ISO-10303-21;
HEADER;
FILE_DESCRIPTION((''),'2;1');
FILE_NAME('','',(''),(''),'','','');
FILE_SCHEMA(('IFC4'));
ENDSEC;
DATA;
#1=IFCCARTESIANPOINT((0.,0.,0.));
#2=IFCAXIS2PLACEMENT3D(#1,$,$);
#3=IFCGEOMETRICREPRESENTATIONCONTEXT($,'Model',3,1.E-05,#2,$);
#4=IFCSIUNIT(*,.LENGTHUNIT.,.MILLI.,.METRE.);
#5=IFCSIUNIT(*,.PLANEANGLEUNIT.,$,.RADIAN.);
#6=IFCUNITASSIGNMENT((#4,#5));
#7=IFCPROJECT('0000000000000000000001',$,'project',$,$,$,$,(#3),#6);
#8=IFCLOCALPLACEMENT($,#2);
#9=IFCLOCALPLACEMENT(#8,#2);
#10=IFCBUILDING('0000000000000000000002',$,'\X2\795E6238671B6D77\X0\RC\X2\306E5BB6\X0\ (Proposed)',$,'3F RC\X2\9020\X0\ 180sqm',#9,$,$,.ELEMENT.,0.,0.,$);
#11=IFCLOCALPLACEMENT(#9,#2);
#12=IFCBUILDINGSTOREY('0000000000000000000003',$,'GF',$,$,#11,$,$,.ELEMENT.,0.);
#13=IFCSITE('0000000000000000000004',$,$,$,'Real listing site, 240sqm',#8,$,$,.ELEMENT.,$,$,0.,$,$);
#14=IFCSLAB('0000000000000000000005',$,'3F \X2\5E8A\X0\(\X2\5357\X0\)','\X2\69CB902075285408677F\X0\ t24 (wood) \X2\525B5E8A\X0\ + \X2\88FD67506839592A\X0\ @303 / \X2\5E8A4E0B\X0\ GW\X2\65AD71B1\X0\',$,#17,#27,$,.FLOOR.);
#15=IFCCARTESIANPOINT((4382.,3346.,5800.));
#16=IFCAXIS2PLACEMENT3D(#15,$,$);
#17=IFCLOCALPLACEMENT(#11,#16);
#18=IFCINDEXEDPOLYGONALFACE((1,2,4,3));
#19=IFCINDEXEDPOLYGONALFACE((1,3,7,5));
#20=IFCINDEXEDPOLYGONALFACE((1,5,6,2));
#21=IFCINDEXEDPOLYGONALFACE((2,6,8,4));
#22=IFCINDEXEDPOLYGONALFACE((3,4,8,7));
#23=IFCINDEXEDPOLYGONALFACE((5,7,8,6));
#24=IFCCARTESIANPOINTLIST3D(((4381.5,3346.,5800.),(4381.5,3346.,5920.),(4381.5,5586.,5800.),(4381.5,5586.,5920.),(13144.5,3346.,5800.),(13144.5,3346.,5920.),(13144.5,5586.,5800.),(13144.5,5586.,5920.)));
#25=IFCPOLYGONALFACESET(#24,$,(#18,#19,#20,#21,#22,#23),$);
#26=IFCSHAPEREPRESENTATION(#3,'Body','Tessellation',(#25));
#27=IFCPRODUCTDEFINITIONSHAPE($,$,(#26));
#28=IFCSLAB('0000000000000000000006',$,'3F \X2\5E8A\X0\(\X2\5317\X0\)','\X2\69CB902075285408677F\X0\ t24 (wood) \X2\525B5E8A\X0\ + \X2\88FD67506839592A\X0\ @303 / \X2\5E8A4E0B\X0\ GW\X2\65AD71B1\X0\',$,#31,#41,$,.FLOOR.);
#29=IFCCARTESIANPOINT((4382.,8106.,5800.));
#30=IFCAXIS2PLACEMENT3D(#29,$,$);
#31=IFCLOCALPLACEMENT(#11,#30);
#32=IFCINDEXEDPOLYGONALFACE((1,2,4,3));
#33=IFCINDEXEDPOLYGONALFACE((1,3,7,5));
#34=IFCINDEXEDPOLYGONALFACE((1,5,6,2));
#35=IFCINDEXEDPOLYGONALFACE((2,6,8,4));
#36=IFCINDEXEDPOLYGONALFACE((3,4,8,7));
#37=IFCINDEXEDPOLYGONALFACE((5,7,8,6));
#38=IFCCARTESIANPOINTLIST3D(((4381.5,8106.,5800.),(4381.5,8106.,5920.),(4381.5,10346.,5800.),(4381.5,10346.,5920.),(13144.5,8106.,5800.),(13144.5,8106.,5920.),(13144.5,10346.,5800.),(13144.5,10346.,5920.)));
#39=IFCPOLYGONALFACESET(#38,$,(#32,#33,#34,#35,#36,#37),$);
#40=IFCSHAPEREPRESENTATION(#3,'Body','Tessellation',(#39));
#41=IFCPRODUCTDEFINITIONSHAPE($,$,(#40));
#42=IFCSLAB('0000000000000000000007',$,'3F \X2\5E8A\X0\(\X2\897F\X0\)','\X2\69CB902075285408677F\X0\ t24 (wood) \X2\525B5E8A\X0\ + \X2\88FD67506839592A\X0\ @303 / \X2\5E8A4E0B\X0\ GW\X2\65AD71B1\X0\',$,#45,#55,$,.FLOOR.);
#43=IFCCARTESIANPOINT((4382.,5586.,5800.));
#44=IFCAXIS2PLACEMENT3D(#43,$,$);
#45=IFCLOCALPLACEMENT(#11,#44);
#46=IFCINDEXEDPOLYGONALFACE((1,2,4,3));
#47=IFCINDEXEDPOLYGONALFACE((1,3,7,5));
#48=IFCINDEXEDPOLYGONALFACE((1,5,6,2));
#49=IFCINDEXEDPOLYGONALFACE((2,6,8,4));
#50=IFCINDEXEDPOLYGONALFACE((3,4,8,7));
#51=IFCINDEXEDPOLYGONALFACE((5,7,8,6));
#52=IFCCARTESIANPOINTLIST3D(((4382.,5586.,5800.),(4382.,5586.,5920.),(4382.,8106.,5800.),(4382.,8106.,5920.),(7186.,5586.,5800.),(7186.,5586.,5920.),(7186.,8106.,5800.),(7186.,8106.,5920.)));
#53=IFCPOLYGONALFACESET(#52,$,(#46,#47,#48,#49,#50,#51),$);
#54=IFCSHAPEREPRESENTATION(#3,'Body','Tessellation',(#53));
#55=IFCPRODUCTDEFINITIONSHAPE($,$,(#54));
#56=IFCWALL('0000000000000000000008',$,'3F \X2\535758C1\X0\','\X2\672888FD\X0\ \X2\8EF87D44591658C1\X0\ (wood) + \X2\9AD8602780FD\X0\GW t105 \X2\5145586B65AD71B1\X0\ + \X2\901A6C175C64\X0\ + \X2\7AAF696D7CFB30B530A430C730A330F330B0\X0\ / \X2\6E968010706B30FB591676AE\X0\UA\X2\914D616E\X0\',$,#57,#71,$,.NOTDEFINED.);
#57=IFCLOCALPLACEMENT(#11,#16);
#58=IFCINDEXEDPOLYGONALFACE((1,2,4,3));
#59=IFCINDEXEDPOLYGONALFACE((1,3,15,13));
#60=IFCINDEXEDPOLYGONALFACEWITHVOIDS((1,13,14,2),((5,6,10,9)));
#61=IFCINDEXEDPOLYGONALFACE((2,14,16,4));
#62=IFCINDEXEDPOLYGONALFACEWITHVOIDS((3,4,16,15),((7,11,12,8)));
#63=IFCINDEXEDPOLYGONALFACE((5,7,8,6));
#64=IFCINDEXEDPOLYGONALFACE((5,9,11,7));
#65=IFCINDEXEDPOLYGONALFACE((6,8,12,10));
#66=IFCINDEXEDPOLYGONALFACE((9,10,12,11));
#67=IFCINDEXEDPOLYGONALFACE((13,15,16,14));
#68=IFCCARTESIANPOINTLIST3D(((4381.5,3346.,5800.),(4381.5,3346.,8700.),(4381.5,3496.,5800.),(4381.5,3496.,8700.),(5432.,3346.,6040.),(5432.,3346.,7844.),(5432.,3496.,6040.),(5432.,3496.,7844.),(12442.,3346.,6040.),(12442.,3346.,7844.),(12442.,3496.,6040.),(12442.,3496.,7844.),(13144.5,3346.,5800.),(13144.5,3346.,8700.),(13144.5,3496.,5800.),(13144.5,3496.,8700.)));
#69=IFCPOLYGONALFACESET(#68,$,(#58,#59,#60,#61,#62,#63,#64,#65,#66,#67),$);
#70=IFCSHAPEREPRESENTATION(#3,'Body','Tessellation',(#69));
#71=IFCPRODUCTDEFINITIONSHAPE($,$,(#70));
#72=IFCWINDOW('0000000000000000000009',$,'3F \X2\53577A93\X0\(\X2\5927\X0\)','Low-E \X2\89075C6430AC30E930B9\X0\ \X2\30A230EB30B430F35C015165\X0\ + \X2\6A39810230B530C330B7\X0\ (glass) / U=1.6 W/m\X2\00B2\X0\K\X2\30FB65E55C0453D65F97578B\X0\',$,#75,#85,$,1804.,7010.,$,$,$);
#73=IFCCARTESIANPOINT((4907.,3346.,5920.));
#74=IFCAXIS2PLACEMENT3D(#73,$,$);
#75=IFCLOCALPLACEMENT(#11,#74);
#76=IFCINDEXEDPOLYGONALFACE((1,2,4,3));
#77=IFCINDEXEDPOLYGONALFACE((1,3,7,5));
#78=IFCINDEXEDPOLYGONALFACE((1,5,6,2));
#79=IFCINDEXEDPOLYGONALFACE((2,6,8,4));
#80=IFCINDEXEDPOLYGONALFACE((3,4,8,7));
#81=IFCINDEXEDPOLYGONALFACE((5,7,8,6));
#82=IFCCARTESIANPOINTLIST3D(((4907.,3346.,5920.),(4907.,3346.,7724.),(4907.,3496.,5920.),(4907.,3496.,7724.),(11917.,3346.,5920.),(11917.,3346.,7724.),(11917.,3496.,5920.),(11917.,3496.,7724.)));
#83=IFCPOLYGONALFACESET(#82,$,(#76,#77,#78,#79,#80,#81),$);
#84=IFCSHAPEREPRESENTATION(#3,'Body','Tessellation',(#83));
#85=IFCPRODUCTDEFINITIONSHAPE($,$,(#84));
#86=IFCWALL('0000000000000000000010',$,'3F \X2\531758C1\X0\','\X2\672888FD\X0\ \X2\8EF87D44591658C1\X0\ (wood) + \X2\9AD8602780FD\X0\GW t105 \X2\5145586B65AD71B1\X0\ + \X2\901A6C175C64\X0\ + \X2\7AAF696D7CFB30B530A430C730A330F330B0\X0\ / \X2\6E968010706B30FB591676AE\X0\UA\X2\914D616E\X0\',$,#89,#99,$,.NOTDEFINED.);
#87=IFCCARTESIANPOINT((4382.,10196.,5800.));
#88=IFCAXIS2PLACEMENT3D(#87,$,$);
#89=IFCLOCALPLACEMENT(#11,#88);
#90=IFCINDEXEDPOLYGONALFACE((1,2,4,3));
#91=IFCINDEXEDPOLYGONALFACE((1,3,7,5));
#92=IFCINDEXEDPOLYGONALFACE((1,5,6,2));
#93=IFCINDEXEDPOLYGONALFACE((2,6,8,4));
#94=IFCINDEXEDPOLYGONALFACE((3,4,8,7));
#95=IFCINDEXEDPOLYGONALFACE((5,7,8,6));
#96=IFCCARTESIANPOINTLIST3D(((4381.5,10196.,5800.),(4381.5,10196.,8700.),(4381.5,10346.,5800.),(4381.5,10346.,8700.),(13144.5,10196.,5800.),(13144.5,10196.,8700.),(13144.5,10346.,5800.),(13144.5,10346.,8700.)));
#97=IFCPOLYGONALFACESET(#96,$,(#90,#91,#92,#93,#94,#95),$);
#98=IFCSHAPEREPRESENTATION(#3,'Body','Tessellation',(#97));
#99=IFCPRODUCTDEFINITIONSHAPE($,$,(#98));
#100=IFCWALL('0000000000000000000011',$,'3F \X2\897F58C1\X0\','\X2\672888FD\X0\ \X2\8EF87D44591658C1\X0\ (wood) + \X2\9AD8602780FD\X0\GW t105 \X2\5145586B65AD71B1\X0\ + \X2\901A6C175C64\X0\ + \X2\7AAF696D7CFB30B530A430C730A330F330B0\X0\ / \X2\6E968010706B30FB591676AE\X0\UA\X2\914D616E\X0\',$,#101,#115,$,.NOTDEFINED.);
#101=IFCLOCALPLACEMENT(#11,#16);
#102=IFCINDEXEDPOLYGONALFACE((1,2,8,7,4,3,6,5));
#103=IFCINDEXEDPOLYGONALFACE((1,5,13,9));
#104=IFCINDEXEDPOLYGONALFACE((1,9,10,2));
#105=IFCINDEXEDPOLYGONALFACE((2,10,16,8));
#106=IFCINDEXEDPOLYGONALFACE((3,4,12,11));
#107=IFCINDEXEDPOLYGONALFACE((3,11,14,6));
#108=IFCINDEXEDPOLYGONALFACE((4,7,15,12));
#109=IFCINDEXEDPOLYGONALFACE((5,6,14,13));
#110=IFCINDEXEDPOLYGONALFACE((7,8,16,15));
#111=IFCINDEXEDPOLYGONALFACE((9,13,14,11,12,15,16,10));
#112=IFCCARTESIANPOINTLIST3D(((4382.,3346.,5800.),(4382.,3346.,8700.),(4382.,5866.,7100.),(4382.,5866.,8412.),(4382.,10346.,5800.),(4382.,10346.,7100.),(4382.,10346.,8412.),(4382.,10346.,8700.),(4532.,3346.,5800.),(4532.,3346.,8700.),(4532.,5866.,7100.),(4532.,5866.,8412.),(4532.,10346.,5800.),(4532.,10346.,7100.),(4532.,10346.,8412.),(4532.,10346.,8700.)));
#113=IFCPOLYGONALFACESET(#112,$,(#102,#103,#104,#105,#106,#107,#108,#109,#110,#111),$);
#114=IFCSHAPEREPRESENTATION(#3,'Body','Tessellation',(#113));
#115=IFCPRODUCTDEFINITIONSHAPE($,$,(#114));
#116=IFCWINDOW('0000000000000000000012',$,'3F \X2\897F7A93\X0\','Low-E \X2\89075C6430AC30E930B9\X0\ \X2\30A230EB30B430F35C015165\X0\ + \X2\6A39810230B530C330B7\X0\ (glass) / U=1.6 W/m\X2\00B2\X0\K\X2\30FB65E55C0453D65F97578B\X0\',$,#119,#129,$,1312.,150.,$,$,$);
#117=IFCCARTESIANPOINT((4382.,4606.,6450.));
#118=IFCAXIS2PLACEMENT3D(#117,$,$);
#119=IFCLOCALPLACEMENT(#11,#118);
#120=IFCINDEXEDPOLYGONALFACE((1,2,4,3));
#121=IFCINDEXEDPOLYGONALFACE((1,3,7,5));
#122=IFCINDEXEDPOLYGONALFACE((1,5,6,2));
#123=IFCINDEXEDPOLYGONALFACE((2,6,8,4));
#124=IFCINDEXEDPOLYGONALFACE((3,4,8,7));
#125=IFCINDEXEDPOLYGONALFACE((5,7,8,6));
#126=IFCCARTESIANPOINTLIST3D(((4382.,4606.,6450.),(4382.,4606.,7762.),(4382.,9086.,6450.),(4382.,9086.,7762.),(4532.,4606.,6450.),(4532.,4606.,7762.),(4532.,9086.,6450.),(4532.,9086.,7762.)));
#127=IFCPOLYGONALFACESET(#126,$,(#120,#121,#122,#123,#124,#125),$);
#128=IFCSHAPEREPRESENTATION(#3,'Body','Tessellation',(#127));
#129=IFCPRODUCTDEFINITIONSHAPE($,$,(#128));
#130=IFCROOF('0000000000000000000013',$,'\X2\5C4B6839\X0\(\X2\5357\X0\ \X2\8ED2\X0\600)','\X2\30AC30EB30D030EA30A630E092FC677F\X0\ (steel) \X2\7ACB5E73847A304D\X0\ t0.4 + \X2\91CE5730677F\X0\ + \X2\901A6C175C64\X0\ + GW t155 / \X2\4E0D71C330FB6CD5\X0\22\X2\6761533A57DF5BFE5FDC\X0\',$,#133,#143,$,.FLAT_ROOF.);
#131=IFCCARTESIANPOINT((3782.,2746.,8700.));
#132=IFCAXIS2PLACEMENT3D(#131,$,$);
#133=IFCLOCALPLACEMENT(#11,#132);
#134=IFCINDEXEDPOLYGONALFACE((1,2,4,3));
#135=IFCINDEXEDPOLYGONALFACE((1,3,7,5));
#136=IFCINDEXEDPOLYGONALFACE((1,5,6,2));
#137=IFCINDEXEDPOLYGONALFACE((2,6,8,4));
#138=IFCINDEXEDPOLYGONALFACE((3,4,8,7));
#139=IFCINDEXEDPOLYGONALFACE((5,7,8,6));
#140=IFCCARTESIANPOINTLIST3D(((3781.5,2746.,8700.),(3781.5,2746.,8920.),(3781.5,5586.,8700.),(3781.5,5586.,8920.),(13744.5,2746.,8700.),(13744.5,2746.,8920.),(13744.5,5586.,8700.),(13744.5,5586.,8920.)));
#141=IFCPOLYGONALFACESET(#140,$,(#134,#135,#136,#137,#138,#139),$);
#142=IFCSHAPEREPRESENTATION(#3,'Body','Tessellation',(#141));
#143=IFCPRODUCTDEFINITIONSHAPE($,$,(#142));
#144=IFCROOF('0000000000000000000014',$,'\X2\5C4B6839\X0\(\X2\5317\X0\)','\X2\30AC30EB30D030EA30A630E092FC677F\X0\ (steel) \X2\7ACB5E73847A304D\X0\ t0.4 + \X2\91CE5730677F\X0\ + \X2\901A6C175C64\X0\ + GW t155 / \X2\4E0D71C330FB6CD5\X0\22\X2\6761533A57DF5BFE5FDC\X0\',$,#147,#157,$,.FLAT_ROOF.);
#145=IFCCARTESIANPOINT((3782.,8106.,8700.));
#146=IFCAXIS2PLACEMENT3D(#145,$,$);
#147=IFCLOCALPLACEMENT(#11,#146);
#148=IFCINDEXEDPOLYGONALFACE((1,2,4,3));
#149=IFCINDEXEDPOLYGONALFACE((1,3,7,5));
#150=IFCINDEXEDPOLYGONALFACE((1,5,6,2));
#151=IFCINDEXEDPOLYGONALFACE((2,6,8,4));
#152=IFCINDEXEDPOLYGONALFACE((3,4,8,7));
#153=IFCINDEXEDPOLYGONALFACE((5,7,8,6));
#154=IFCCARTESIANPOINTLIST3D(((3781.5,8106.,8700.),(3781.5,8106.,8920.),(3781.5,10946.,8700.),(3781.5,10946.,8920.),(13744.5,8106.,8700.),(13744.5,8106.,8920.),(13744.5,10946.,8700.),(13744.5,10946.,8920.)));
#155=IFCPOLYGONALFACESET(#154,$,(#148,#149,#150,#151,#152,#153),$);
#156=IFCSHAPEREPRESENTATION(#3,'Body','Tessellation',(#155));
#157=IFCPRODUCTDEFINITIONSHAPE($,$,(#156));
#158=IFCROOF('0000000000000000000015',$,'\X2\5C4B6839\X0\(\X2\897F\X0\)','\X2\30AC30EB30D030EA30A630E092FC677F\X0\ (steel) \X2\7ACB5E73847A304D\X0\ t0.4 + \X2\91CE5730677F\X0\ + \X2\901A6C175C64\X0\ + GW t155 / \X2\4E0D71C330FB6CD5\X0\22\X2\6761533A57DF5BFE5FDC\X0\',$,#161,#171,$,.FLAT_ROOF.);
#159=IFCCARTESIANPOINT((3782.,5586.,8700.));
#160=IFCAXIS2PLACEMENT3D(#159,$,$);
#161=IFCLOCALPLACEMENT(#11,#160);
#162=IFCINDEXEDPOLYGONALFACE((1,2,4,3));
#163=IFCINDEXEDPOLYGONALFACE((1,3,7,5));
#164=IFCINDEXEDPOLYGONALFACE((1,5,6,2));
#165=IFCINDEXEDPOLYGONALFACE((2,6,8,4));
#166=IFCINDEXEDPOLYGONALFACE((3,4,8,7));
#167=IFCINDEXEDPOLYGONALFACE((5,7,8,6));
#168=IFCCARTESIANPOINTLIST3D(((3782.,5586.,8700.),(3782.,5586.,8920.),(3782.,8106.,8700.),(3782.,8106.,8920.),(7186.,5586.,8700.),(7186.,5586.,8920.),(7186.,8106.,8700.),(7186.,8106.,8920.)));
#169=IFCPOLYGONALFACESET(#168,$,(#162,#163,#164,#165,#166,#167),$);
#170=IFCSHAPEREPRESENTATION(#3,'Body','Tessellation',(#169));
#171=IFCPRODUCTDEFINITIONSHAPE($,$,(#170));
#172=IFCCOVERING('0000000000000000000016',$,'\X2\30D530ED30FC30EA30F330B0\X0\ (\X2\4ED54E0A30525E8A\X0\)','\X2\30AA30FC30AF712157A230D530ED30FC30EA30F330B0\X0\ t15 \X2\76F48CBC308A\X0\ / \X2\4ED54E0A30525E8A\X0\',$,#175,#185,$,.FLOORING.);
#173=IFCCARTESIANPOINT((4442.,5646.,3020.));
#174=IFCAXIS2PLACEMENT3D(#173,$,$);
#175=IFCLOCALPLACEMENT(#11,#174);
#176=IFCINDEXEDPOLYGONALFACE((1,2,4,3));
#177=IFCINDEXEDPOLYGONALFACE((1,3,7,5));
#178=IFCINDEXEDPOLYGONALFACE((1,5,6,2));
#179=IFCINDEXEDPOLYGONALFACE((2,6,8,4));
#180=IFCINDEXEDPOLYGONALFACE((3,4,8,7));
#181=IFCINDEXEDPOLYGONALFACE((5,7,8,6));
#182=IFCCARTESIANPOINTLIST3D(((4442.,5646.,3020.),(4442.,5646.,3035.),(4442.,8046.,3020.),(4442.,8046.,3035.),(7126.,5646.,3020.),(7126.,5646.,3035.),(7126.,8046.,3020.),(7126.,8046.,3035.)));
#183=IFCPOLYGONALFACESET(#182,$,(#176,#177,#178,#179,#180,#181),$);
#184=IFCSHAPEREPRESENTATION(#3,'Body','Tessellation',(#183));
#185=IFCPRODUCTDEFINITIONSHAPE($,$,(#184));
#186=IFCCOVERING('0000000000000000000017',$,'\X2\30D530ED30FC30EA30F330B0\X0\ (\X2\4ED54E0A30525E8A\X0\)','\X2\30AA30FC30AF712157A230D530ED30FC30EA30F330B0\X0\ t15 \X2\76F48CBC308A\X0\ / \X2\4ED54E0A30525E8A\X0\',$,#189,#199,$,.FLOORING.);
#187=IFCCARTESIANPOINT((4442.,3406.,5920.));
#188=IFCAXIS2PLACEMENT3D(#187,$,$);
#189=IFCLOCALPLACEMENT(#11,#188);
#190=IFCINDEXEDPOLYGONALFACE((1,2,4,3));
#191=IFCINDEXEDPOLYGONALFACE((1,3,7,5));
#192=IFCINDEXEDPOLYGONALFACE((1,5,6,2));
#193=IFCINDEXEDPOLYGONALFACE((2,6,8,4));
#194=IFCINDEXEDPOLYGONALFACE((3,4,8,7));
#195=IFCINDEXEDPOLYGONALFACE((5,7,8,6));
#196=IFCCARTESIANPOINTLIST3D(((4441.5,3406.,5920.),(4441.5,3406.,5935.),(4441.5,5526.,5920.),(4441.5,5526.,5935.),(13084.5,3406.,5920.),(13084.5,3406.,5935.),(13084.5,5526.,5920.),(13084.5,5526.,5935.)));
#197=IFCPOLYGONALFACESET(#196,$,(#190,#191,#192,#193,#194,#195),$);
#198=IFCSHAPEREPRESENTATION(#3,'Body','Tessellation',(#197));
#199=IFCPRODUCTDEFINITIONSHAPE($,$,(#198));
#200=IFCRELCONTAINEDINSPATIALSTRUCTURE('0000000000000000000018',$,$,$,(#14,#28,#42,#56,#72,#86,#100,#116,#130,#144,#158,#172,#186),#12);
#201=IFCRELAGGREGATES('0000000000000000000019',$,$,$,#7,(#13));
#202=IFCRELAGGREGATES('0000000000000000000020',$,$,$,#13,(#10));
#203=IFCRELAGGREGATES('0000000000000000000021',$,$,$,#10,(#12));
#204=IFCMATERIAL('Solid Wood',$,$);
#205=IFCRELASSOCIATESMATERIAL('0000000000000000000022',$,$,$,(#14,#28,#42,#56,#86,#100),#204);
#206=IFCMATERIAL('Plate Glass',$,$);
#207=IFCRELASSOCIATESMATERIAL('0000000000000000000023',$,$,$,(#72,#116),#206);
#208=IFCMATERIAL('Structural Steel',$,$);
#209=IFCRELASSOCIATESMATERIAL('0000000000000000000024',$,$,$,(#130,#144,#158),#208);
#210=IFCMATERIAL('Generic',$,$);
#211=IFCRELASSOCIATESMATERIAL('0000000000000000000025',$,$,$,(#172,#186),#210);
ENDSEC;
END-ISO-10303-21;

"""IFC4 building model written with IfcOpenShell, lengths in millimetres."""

from ifc_helpers import new_model, si_unit, frame, frame_2d, origin, place, context, project, spatial, rectangle, extrude, material, element, fill, save


model = new_model("IFC4")

# Units and contexts
model_context = context("Model", 3, precision=1e-05, world=origin())
ifc_project = project(units=[si_unit("LENGTHUNIT", "METRE", prefix="MILLI"), si_unit("PLANEANGLEUNIT", "RADIAN")], contexts=[model_context])

# Site, building, storey
site_placement = place(None, origin())
site = spatial("IfcSite", under=ifc_project, at=site_placement, ObjectType="Real listing site, 240sqm", CompositionType="ELEMENT", RefElevation=0.0)
building_placement = place(site_placement, origin())
building = spatial("IfcBuilding", under=site, at=building_placement, Name="神戸望海RCの家 (Proposed)", ObjectType="3F RC造 180sqm", CompositionType="ELEMENT", ElevationOfRefHeight=0.0, ElevationOfTerrain=0.0)
storey_placement = place(building_placement, origin())
storey = spatial("IfcBuildingStorey", under=building, at=storey_placement, Name="GF", CompositionType="ELEMENT", Elevation=0.0)

# Slabs
ifc_material_1 = material(Name="Solid Wood")
slab_1_placement = place(storey_placement, frame((4382.0, 3346.0, 5800.0)))
element("IfcSlab", 1, at=slab_1_placement, inside=storey, material=ifc_material_1, Name="3F 床(南)", Description="構造用合板 t24 (wood) 剛床 + 製材根太 @303 / 床下 GW断熱", PredefinedType="FLOOR", context=model_context, shape_type="SweptSolid", body=[
    extrude(rectangle(XDim=8763.0, YDim=2240.0, at=frame_2d((4381.0, 1120.0))), frame((4382.0, 3346.0, 5800.0)), (0.0, 0.0, 1.0), 120.0),
])
slab_2_placement = place(storey_placement, frame((4382.0, 8106.0, 5800.0)))
element("IfcSlab", 2, at=slab_2_placement, inside=storey, material=ifc_material_1, Name="3F 床(北)", Description="構造用合板 t24 (wood) 剛床 + 製材根太 @303 / 床下 GW断熱", PredefinedType="FLOOR", context=model_context, shape_type="SweptSolid", body=[
    extrude(rectangle(XDim=8763.0, YDim=2240.0, at=frame_2d((4381.0, 1120.0))), frame((4382.0, 8106.0, 5800.0)), (0.0, 0.0, 1.0), 120.0),
])
slab_3_placement = place(storey_placement, frame((4382.0, 5586.0, 5800.0)))
element("IfcSlab", 3, at=slab_3_placement, inside=storey, material=ifc_material_1, Name="3F 床(西)", Description="構造用合板 t24 (wood) 剛床 + 製材根太 @303 / 床下 GW断熱", PredefinedType="FLOOR", context=model_context, shape_type="SweptSolid", body=[
    extrude(rectangle(XDim=2804.0, YDim=2520.0, at=frame_2d((1402.0, 1260.0))), frame((4382.0, 5586.0, 5800.0)), (0.0, 0.0, 1.0), 120.0),
])

# Wall, opening, window
wall_1_placement = place(storey_placement, frame((4382.0, 3346.0, 5800.0)))
wall_1 = element("IfcWall", 4, at=wall_1_placement, inside=storey, material=ifc_material_1, Name="3F 南壁", Description="木製 軸組外壁 (wood) + 高性能GW t105 充填断熱 + 通気層 + 窯業系サイディング / 準耐火・外皮UA配慮", PredefinedType="NOTDEFINED", context=model_context, shape_type="SweptSolid", body=[
    extrude(rectangle(XDim=8763.0, YDim=150.0, at=frame_2d((4381.0, 75.0))), frame((4382.0, 3346.0, 5800.0)), (0.0, 0.0, 1.0), 2900.0),
])
opening_1_placement = place(storey_placement, frame((4907.0, 3346.0, 5920.0)))
opening_1 = element("IfcOpeningElement", 5, at=opening_1_placement, cuts=wall_1, PredefinedType="NOTDEFINED", context=model_context, shape_type="SweptSolid", body=[
    extrude(rectangle(XDim=7010.0, YDim=150.0, at=frame_2d((3505.0, 75.0))), frame((4907.0, 3346.0, 5920.0)), (0.0, 0.0, 1.0), 1804.0),
])
ifc_material_2 = material(Name="Plate Glass")
window_1_placement = place(storey_placement, frame((4907.0, 3346.0, 5920.0)))
window_1 = element("IfcWindow", 6, at=window_1_placement, inside=storey, material=ifc_material_2, Name="3F 南窓(大)", Description="Low-E 複層ガラス アルゴン封入 + 樹脂サッシ (glass) / U=1.6 W/m²K・日射取得型", OverallHeight=1804.0, OverallWidth=7010.0, context=model_context, shape_type="SweptSolid", body=[
    extrude(rectangle(XDim=7010.0, YDim=150.0, at=frame_2d((3505.0, 75.0))), frame((4907.0, 3346.0, 5920.0)), (0.0, 0.0, 1.0), 1804.0),
])
fill(opening_1, window_1)

# Wall
wall_2_placement = place(storey_placement, frame((4382.0, 10196.0, 5800.0)))
element("IfcWall", 7, at=wall_2_placement, inside=storey, material=ifc_material_1, Name="3F 北壁", Description="木製 軸組外壁 (wood) + 高性能GW t105 充填断熱 + 通気層 + 窯業系サイディング / 準耐火・外皮UA配慮", PredefinedType="NOTDEFINED", context=model_context, shape_type="SweptSolid", body=[
    extrude(rectangle(XDim=8763.0, YDim=150.0, at=frame_2d((4381.0, 75.0))), frame((4382.0, 10196.0, 5800.0)), (0.0, 0.0, 1.0), 2900.0),
])

# Wall, opening, window
wall_3_placement = place(storey_placement, frame((4382.0, 3346.0, 5800.0)))
wall_3 = element("IfcWall", 8, at=wall_3_placement, inside=storey, material=ifc_material_1, Name="3F 西壁", Description="木製 軸組外壁 (wood) + 高性能GW t105 充填断熱 + 通気層 + 窯業系サイディング / 準耐火・外皮UA配慮", PredefinedType="NOTDEFINED", context=model_context, shape_type="SweptSolid", body=[
    extrude(rectangle(XDim=150.0, YDim=7000.0, at=frame_2d((75.0, 3500.0))), frame((4382.0, 3346.0, 5800.0)), (0.0, 0.0, 1.0), 2900.0),
])
opening_2_placement = place(storey_placement, frame((4382.0, 4606.0, 6450.0)))
opening_2 = element("IfcOpeningElement", 9, at=opening_2_placement, cuts=wall_3, PredefinedType="NOTDEFINED", context=model_context, shape_type="SweptSolid", body=[
    extrude(rectangle(XDim=150.0, YDim=4480.0, at=frame_2d((75.0, 2240.0))), frame((4382.0, 4606.0, 6450.0)), (0.0, 0.0, 1.0), 1312.0),
])
window_2_placement = place(storey_placement, frame((4382.0, 4606.0, 6450.0)))
window_2 = element("IfcWindow", 10, at=window_2_placement, inside=storey, material=ifc_material_2, Name="3F 西窓", Description="Low-E 複層ガラス アルゴン封入 + 樹脂サッシ (glass) / U=1.6 W/m²K・日射取得型", OverallHeight=1312.0, OverallWidth=150.0, context=model_context, shape_type="SweptSolid", body=[
    extrude(rectangle(XDim=150.0, YDim=4480.0, at=frame_2d((75.0, 2240.0))), frame((4382.0, 4606.0, 6450.0)), (0.0, 0.0, 1.0), 1312.0),
])
fill(opening_2, window_2)

# Roofs
ifc_material_3 = material(Name="Structural Steel")
roof_1_placement = place(storey_placement, frame((3782.0, 2746.0, 8700.0)))
element("IfcRoof", 11, at=roof_1_placement, inside=storey, material=ifc_material_3, Name="屋根(南 軒600)", Description="ガルバリウム鋼板 (steel) 立平葺き t0.4 + 野地板 + 通気層 + GW t155 / 不燃・法22条区域対応", PredefinedType="FLAT_ROOF", context=model_context, shape_type="SweptSolid", body=[
    extrude(rectangle(XDim=9963.0, YDim=2840.0, at=frame_2d((4981.0, 1420.0))), frame((3782.0, 2746.0, 8700.0)), (0.0, 0.0, 1.0), 220.0),
])
roof_2_placement = place(storey_placement, frame((3782.0, 8106.0, 8700.0)))
element("IfcRoof", 12, at=roof_2_placement, inside=storey, material=ifc_material_3, Name="屋根(北)", Description="ガルバリウム鋼板 (steel) 立平葺き t0.4 + 野地板 + 通気層 + GW t155 / 不燃・法22条区域対応", PredefinedType="FLAT_ROOF", context=model_context, shape_type="SweptSolid", body=[
    extrude(rectangle(XDim=9963.0, YDim=2840.0, at=frame_2d((4981.0, 1420.0))), frame((3782.0, 8106.0, 8700.0)), (0.0, 0.0, 1.0), 220.0),
])
roof_3_placement = place(storey_placement, frame((3782.0, 5586.0, 8700.0)))
element("IfcRoof", 13, at=roof_3_placement, inside=storey, material=ifc_material_3, Name="屋根(西)", Description="ガルバリウム鋼板 (steel) 立平葺き t0.4 + 野地板 + 通気層 + GW t155 / 不燃・法22条区域対応", PredefinedType="FLAT_ROOF", context=model_context, shape_type="SweptSolid", body=[
    extrude(rectangle(XDim=3404.0, YDim=2520.0, at=frame_2d((1702.0, 1260.0))), frame((3782.0, 5586.0, 8700.0)), (0.0, 0.0, 1.0), 220.0),
])

# Coverings
ifc_material_4 = material(Name="Generic")
covering_1_placement = place(storey_placement, frame((4442.0, 5646.0, 3020.0)))
element("IfcCovering", 14, at=covering_1_placement, inside=storey, material=ifc_material_4, Name="フローリング (仕上げ床)", Description="オーク無垢フローリング t15 直貼り / 仕上げ床", PredefinedType="FLOORING", context=model_context, shape_type="SweptSolid", body=[
    extrude(rectangle(XDim=2684.0, YDim=2400.0, at=frame_2d((1342.0, 1200.0))), frame((4442.0, 5646.0, 3020.0)), (0.0, 0.0, 1.0), 15.0),
])
covering_2_placement = place(storey_placement, frame((4442.0, 3406.0, 5920.0)))
element("IfcCovering", 15, at=covering_2_placement, inside=storey, material=ifc_material_4, Name="フローリング (仕上げ床)", Description="オーク無垢フローリング t15 直貼り / 仕上げ床", PredefinedType="FLOORING", context=model_context, shape_type="SweptSolid", body=[
    extrude(rectangle(XDim=8643.0, YDim=2120.0, at=frame_2d((4321.0, 1060.0))), frame((4442.0, 3406.0, 5920.0)), (0.0, 0.0, 1.0), 15.0),
])

save(model, "model.ifc")
